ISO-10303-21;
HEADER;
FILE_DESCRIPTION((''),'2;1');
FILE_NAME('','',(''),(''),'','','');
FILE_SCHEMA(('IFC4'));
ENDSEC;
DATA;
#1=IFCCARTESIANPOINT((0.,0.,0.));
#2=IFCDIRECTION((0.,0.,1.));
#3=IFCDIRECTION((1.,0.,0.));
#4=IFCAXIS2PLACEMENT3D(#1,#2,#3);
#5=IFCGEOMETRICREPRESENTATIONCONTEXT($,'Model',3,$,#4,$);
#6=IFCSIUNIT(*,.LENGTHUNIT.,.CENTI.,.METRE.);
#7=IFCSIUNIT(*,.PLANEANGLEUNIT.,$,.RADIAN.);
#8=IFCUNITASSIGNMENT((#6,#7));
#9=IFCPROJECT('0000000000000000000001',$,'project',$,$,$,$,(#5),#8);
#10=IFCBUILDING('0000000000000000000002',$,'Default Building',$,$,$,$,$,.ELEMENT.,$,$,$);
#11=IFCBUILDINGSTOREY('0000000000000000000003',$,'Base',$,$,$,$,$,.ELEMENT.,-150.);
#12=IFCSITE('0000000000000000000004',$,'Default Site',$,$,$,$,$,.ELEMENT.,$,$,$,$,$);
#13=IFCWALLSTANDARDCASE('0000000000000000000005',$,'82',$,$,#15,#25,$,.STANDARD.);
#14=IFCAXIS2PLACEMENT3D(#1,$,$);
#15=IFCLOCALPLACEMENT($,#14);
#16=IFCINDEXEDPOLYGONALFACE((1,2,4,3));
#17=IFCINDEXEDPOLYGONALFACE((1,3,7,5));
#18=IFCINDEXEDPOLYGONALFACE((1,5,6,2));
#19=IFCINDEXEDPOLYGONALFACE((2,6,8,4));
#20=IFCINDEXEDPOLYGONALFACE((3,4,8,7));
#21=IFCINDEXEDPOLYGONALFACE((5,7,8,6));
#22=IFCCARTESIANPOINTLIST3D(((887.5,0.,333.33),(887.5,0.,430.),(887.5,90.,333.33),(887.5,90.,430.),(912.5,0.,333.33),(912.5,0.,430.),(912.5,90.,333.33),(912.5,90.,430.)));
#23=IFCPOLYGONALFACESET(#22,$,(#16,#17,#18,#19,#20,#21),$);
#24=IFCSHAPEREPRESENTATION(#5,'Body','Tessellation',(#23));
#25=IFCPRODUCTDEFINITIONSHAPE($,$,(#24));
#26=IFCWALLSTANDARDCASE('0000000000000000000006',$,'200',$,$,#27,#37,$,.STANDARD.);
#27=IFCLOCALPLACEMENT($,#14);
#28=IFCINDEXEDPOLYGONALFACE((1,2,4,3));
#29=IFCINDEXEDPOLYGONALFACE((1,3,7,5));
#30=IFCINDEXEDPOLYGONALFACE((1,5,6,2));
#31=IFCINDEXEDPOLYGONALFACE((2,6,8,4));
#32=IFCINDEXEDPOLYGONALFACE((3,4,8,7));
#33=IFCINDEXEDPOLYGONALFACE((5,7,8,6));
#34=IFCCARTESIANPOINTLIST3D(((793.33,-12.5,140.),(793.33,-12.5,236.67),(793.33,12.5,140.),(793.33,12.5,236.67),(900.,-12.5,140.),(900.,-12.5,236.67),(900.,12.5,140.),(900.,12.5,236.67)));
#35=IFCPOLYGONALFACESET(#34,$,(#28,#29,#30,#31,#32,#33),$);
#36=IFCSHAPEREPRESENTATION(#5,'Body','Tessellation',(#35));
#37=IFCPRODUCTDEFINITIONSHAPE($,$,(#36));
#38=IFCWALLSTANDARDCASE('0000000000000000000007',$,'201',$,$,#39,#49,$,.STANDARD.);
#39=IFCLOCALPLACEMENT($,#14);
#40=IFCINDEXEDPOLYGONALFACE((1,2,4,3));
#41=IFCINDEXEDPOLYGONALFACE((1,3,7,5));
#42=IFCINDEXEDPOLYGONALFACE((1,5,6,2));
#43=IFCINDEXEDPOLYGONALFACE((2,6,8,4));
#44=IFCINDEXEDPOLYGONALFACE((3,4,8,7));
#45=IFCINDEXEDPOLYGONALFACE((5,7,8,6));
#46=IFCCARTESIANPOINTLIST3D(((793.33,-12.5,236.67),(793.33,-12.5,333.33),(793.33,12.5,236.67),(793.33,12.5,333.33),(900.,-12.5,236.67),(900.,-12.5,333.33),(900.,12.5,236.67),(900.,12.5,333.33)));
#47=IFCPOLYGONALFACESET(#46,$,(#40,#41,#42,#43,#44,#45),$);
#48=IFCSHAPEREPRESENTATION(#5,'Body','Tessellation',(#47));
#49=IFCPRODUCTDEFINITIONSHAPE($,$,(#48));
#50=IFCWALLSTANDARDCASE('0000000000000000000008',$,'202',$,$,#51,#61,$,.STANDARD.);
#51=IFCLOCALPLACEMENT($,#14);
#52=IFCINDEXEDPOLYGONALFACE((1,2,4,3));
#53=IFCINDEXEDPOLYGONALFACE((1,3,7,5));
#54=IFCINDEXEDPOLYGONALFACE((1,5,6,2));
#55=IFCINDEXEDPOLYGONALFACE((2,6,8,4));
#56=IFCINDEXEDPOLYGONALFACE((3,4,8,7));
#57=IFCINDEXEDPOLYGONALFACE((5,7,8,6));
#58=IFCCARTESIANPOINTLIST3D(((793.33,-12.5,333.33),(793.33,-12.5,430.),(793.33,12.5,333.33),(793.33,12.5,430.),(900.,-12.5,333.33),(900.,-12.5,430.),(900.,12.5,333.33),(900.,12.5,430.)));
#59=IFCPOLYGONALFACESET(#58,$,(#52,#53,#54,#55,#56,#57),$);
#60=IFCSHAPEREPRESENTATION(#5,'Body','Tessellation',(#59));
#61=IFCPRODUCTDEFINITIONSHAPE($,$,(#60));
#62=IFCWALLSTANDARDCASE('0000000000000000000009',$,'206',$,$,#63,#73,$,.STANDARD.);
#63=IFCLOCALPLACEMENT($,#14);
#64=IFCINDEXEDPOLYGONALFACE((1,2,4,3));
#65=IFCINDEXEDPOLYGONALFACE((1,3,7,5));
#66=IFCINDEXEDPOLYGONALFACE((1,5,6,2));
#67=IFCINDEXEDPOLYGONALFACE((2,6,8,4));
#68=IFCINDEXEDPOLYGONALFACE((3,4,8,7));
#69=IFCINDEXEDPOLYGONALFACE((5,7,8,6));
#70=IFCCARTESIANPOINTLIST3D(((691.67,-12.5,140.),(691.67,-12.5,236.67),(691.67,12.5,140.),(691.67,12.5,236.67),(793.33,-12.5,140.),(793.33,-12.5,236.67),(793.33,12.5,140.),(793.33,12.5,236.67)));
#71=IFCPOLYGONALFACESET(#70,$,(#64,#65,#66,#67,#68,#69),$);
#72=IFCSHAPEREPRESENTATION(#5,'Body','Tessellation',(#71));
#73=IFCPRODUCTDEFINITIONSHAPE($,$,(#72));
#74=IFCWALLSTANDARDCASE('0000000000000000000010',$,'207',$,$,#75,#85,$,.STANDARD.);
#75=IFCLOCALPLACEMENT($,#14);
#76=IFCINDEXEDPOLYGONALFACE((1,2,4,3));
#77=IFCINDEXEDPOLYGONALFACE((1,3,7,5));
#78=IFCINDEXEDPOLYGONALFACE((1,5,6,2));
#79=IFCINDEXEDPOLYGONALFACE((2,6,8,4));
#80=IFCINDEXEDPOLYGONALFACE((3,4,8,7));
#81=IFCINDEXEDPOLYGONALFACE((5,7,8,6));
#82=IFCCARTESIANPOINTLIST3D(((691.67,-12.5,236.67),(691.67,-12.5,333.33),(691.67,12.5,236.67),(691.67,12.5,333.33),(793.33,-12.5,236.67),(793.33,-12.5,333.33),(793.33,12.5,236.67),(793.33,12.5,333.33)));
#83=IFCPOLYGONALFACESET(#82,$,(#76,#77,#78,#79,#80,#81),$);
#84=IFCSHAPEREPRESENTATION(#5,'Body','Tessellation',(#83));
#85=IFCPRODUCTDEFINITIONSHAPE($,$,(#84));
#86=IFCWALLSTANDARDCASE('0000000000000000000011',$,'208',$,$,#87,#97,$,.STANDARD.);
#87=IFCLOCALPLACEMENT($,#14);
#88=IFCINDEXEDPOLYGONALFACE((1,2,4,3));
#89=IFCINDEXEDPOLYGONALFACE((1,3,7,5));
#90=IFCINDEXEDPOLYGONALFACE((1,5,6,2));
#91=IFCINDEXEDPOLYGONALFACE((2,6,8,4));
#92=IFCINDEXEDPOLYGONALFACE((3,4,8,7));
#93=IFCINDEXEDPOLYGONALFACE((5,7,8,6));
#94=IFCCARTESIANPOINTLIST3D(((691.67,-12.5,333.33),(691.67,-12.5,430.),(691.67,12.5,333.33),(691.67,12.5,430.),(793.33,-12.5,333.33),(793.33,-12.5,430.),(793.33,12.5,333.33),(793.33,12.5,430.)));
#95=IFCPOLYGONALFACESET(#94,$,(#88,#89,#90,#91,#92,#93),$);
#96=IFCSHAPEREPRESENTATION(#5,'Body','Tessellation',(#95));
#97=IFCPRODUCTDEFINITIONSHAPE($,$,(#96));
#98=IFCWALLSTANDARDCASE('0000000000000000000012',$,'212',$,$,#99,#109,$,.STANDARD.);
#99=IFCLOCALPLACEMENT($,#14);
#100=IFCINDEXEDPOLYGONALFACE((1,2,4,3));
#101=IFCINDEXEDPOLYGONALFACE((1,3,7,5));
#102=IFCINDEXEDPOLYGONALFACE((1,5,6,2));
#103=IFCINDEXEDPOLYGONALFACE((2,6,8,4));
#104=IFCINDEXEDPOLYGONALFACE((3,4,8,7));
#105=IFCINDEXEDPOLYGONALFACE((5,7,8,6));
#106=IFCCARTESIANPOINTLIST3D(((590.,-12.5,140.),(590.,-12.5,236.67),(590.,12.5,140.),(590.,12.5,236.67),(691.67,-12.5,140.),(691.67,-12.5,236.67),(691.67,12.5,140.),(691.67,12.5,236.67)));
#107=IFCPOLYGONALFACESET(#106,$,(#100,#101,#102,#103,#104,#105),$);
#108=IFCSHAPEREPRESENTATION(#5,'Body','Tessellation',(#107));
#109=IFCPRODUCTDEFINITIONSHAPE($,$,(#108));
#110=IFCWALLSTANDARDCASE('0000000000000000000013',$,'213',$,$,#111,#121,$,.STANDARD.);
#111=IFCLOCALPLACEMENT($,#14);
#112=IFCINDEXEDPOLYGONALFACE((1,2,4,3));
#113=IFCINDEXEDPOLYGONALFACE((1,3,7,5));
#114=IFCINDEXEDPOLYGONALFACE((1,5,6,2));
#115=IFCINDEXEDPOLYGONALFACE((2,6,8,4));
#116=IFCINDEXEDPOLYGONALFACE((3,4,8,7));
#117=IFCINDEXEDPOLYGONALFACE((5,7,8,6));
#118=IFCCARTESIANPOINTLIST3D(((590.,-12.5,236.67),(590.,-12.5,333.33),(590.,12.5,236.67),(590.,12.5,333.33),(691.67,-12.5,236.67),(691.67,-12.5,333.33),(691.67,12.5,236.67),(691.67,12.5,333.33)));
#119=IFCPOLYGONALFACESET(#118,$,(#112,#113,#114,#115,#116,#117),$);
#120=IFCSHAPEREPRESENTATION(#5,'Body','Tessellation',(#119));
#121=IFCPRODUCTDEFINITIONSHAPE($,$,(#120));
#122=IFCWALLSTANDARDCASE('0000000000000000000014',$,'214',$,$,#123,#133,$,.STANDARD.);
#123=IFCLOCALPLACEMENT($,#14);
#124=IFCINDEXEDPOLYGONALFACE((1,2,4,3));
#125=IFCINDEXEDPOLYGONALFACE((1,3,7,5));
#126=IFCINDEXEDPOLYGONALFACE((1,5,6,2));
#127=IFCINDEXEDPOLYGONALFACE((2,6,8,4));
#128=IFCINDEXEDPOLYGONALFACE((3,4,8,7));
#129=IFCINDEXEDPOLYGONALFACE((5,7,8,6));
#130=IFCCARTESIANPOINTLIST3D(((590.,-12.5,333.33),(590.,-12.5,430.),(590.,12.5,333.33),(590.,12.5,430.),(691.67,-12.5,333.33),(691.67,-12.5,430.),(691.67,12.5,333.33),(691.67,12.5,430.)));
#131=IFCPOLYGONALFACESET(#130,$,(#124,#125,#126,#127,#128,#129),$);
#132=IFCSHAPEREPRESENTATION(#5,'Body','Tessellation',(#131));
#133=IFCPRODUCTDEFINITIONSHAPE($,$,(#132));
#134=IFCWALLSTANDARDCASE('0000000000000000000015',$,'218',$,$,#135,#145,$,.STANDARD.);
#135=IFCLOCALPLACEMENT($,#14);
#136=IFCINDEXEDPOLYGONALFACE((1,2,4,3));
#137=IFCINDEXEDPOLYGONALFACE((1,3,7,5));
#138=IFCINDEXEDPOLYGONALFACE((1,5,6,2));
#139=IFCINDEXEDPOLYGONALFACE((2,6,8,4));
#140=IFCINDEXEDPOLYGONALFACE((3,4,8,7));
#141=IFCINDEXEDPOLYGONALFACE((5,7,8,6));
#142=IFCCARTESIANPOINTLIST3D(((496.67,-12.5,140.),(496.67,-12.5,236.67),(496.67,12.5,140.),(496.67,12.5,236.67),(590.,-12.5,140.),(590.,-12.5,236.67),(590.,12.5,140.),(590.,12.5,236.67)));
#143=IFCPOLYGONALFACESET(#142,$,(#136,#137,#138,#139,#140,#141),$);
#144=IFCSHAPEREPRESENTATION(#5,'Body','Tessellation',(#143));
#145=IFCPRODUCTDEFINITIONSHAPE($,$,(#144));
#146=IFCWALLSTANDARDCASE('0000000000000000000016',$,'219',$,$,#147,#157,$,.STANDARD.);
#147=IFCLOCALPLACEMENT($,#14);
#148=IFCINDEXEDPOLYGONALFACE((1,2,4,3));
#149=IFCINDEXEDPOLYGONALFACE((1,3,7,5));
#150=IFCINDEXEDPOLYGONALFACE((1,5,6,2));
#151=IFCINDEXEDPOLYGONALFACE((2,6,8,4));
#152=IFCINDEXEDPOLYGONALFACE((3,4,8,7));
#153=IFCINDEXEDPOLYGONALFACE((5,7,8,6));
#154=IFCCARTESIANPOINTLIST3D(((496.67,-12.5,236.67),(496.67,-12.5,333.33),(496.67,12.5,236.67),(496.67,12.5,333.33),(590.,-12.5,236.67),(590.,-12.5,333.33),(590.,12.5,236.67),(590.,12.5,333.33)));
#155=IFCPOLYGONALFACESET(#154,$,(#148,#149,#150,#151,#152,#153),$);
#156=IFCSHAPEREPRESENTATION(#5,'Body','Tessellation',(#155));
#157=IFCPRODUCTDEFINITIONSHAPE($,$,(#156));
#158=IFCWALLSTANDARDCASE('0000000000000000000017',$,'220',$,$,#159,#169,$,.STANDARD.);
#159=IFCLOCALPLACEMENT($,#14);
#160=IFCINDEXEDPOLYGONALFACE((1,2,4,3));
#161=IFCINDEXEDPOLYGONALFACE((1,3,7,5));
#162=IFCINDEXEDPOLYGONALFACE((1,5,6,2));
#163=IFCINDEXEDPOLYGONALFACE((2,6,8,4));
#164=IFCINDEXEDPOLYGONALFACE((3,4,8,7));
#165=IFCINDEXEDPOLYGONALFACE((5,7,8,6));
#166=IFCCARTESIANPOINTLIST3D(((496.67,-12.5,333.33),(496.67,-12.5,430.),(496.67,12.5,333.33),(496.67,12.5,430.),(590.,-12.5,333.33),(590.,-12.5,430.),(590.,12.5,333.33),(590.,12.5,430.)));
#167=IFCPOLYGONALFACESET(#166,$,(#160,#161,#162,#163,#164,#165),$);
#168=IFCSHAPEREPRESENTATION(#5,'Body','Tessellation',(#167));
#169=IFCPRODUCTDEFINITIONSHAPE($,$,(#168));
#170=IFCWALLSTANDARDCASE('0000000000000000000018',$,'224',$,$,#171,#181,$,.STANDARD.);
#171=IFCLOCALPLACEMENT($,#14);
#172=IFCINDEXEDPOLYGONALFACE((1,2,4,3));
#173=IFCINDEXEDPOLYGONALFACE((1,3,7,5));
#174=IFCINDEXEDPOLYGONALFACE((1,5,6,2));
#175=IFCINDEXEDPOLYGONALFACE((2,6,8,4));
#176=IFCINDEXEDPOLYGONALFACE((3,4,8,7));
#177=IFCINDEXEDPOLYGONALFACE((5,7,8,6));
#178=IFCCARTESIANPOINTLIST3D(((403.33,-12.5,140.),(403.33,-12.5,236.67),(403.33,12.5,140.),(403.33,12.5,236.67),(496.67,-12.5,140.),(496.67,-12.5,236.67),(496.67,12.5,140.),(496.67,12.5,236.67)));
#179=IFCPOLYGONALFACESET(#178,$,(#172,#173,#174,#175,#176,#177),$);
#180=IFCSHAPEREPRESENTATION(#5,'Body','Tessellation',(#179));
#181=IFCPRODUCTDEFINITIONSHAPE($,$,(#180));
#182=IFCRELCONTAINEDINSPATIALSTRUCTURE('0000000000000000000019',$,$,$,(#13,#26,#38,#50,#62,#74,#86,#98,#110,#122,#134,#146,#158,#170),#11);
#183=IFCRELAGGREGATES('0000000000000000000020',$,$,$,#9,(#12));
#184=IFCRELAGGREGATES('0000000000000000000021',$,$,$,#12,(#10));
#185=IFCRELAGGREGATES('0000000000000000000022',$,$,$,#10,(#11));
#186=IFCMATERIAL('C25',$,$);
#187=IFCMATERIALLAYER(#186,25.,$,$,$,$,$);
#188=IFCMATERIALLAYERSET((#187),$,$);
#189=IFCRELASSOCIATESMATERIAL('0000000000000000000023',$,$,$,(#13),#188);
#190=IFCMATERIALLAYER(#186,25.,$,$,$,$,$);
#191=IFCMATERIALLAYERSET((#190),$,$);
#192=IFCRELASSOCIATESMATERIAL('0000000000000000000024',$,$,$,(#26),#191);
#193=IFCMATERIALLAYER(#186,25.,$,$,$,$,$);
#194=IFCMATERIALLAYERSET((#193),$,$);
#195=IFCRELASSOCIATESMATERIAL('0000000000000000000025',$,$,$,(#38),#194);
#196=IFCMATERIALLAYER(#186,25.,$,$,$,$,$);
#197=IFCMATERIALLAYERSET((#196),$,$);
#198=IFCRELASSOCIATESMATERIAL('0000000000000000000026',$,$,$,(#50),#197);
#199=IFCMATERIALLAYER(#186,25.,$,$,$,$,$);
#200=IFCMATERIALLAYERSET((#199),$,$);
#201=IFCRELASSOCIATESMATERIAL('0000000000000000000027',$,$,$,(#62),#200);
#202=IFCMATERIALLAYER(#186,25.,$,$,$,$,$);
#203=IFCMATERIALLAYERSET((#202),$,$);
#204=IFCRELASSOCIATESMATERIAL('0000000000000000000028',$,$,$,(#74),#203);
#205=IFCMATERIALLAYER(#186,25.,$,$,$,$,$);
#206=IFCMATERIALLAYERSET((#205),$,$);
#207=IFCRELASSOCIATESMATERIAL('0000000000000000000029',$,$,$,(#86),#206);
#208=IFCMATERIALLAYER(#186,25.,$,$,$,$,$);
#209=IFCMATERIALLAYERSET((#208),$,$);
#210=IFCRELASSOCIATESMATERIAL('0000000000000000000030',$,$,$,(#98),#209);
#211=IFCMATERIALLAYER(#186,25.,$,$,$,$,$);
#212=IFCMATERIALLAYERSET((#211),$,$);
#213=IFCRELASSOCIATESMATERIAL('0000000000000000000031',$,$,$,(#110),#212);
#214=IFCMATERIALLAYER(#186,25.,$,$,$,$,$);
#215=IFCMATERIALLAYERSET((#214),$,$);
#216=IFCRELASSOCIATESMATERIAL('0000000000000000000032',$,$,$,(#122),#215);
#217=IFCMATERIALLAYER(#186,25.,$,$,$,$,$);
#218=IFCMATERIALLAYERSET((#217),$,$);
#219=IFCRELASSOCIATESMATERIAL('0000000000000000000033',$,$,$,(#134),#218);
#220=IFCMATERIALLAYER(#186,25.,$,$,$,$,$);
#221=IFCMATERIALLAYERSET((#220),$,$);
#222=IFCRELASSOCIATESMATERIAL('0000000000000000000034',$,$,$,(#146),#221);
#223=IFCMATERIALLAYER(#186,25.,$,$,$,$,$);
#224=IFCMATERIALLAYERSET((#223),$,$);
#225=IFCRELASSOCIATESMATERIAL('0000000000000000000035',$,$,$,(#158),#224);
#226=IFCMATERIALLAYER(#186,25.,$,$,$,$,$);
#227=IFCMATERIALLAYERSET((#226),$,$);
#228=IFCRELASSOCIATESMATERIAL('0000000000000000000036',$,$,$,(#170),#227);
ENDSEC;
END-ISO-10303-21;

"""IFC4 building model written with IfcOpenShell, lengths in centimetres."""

from ifc_helpers import new_model, si_unit, frame, origin_with_axes, origin_2d_with_axis, place, context, project, spatial, rectangle, extrude, material, layer, layer_set, layer_usage, element, save


model = new_model("IFC4")

# Units and contexts
model_context = context("Model", 3, world=origin_with_axes())
ifc_project = project(units=[si_unit("LENGTHUNIT", "METRE", prefix="CENTI"), si_unit("PLANEANGLEUNIT", "RADIAN")], contexts=[model_context])

# Site, building, storey
site = spatial("IfcSite", under=ifc_project, Name="Default Site", CompositionType="ELEMENT")
building = spatial("IfcBuilding", under=site, Name="Default Building", CompositionType="ELEMENT")
storey = spatial("IfcBuildingStorey", under=building, Name="Base", CompositionType="ELEMENT", Elevation=-150.0)

# Walls
ifc_material = material(Name="C25")
ifc_layer_1 = layer(ifc_material, 25.0)
ifc_layer_set_1 = layer_set([ifc_layer_1])
ifc_layer_usage_1 = layer_usage(ifc_layer_set_1, "AXIS2", "POSITIVE", -25.0)
wall_1_placement = place(None, frame((900.0, 45.0, 333.33), z_axis=(0.0, 0.0, 1.0), x_axis=(0.0, -1.0, 0.0)))
element("IfcWallStandardCase", 1, at=wall_1_placement, inside=storey, material=ifc_layer_usage_1, Name="82", PredefinedType="STANDARD", context=model_context, shape_type="SweptSolid", body=[
    extrude(rectangle(XDim=90.0, YDim=25.0, at=origin_2d_with_axis()), origin_with_axes(), (0.0, 0.0, 1.0), 96.67),
])
ifc_layer_2 = layer(ifc_material, 25.0)
ifc_layer_set_2 = layer_set([ifc_layer_2])
ifc_layer_usage_2 = layer_usage(ifc_layer_set_2, "AXIS2", "POSITIVE", -25.0)
wall_2_placement = place(None, frame((846.67, 0.0, 140.0), z_axis=(0.0, 0.0, 1.0), x_axis=(-1.0, 0.0, 0.0)))
element("IfcWallStandardCase", 2, at=wall_2_placement, inside=storey, material=ifc_layer_usage_2, Name="200", PredefinedType="STANDARD", context=model_context, shape_type="SweptSolid", body=[
    extrude(rectangle(XDim=106.67, YDim=25.0, at=origin_2d_with_axis()), origin_with_axes(), (0.0, 0.0, 1.0), 96.67),
])
ifc_layer_3 = layer(ifc_material, 25.0)
ifc_layer_set_3 = layer_set([ifc_layer_3])
ifc_layer_usage_3 = layer_usage(ifc_layer_set_3, "AXIS2", "POSITIVE", -25.0)
wall_3_placement = place(None, frame((846.67, 0.0, 236.67), z_axis=(0.0, 0.0, 1.0), x_axis=(-1.0, 0.0, 0.0)))
element("IfcWallStandardCase", 3, at=wall_3_placement, inside=storey, material=ifc_layer_usage_3, Name="201", PredefinedType="STANDARD", context=model_context, shape_type="SweptSolid", body=[
    extrude(rectangle(XDim=106.67, YDim=25.0, at=origin_2d_with_axis()), origin_with_axes(), (0.0, 0.0, 1.0), 96.67),
])
ifc_layer_4 = layer(ifc_material, 25.0)
ifc_layer_set_4 = layer_set([ifc_layer_4])
ifc_layer_usage_4 = layer_usage(ifc_layer_set_4, "AXIS2", "POSITIVE", -25.0)
wall_4_placement = place(None, frame((846.67, 0.0, 333.33), z_axis=(0.0, 0.0, 1.0), x_axis=(-1.0, 0.0, 0.0)))
element("IfcWallStandardCase", 4, at=wall_4_placement, inside=storey, material=ifc_layer_usage_4, Name="202", PredefinedType="STANDARD", context=model_context, shape_type="SweptSolid", body=[
    extrude(rectangle(XDim=106.67, YDim=25.0, at=origin_2d_with_axis()), origin_with_axes(), (0.0, 0.0, 1.0), 96.67),
])
ifc_layer_5 = layer(ifc_material, 25.0)
ifc_layer_set_5 = layer_set([ifc_layer_5])
ifc_layer_usage_5 = layer_usage(ifc_layer_set_5, "AXIS2", "POSITIVE", -25.0)
wall_5_placement = place(None, frame((742.5, 0.0, 140.0), z_axis=(0.0, 0.0, 1.0), x_axis=(-1.0, 0.0, 0.0)))
element("IfcWallStandardCase", 5, at=wall_5_placement, inside=storey, material=ifc_layer_usage_5, Name="206", PredefinedType="STANDARD", context=model_context, shape_type="SweptSolid", body=[
    extrude(rectangle(XDim=101.67, YDim=25.0, at=origin_2d_with_axis()), origin_with_axes(), (0.0, 0.0, 1.0), 96.67),
])
ifc_layer_6 = layer(ifc_material, 25.0)
ifc_layer_set_6 = layer_set([ifc_layer_6])
ifc_layer_usage_6 = layer_usage(ifc_layer_set_6, "AXIS2", "POSITIVE", -25.0)
wall_6_placement = place(None, frame((742.5, 0.0, 236.67), z_axis=(0.0, 0.0, 1.0), x_axis=(-1.0, 0.0, 0.0)))
element("IfcWallStandardCase", 6, at=wall_6_placement, inside=storey, material=ifc_layer_usage_6, Name="207", PredefinedType="STANDARD", context=model_context, shape_type="SweptSolid", body=[
    extrude(rectangle(XDim=101.67, YDim=25.0, at=origin_2d_with_axis()), origin_with_axes(), (0.0, 0.0, 1.0), 96.67),
])
ifc_layer_7 = layer(ifc_material, 25.0)
ifc_layer_set_7 = layer_set([ifc_layer_7])
ifc_layer_usage_7 = layer_usage(ifc_layer_set_7, "AXIS2", "POSITIVE", -25.0)
wall_7_placement = place(None, frame((742.5, 0.0, 333.33), z_axis=(0.0, 0.0, 1.0), x_axis=(-1.0, 0.0, 0.0)))
element("IfcWallStandardCase", 7, at=wall_7_placement, inside=storey, material=ifc_layer_usage_7, Name="208", PredefinedType="STANDARD", context=model_context, shape_type="SweptSolid", body=[
    extrude(rectangle(XDim=101.67, YDim=25.0, at=origin_2d_with_axis()), origin_with_axes(), (0.0, 0.0, 1.0), 96.67),
])
ifc_layer_8 = layer(ifc_material, 25.0)
ifc_layer_set_8 = layer_set([ifc_layer_8])
ifc_layer_usage_8 = layer_usage(ifc_layer_set_8, "AXIS2", "POSITIVE", -25.0)
wall_8_placement = place(None, frame((640.83, 0.0, 140.0), z_axis=(0.0, 0.0, 1.0), x_axis=(-1.0, 0.0, 0.0)))
element("IfcWallStandardCase", 8, at=wall_8_placement, inside=storey, material=ifc_layer_usage_8, Name="212", PredefinedType="STANDARD", context=model_context, shape_type="SweptSolid", body=[
    extrude(rectangle(XDim=101.67, YDim=25.0, at=origin_2d_with_axis()), origin_with_axes(), (0.0, 0.0, 1.0), 96.67),
])
ifc_layer_9 = layer(ifc_material, 25.0)
ifc_layer_set_9 = layer_set([ifc_layer_9])
ifc_layer_usage_9 = layer_usage(ifc_layer_set_9, "AXIS2", "POSITIVE", -25.0)
wall_9_placement = place(None, frame((640.83, 0.0, 236.67), z_axis=(0.0, 0.0, 1.0), x_axis=(-1.0, 0.0, 0.0)))
element("IfcWallStandardCase", 9, at=wall_9_placement, inside=storey, material=ifc_layer_usage_9, Name="213", PredefinedType="STANDARD", context=model_context, shape_type="SweptSolid", body=[
    extrude(rectangle(XDim=101.67, YDim=25.0, at=origin_2d_with_axis()), origin_with_axes(), (0.0, 0.0, 1.0), 96.67),
])
ifc_layer_10 = layer(ifc_material, 25.0)
ifc_layer_set_10 = layer_set([ifc_layer_10])
ifc_layer_usage_10 = layer_usage(ifc_layer_set_10, "AXIS2", "POSITIVE", -25.0)
wall_10_placement = place(None, frame((640.83, 0.0, 333.33), z_axis=(0.0, 0.0, 1.0), x_axis=(-1.0, 0.0, 0.0)))
element("IfcWallStandardCase", 10, at=wall_10_placement, inside=storey, material=ifc_layer_usage_10, Name="214", PredefinedType="STANDARD", context=model_context, shape_type="SweptSolid", body=[
    extrude(rectangle(XDim=101.67, YDim=25.0, at=origin_2d_with_axis()), origin_with_axes(), (0.0, 0.0, 1.0), 96.67),
])
ifc_layer_11 = layer(ifc_material, 25.0)
ifc_layer_set_11 = layer_set([ifc_layer_11])
ifc_layer_usage_11 = layer_usage(ifc_layer_set_11, "AXIS2", "POSITIVE", -25.0)
wall_11_placement = place(None, frame((543.33, 0.0, 140.0), z_axis=(0.0, 0.0, 1.0), x_axis=(-1.0, 0.0, 0.0)))
element("IfcWallStandardCase", 11, at=wall_11_placement, inside=storey, material=ifc_layer_usage_11, Name="218", PredefinedType="STANDARD", context=model_context, shape_type="SweptSolid", body=[
    extrude(rectangle(XDim=93.33, YDim=25.0, at=origin_2d_with_axis()), origin_with_axes(), (0.0, 0.0, 1.0), 96.67),
])
ifc_layer_12 = layer(ifc_material, 25.0)
ifc_layer_set_12 = layer_set([ifc_layer_12])
ifc_layer_usage_12 = layer_usage(ifc_layer_set_12, "AXIS2", "POSITIVE", -25.0)
wall_12_placement = place(None, frame((543.33, 0.0, 236.67), z_axis=(0.0, 0.0, 1.0), x_axis=(-1.0, 0.0, 0.0)))
element("IfcWallStandardCase", 12, at=wall_12_placement, inside=storey, material=ifc_layer_usage_12, Name="219", PredefinedType="STANDARD", context=model_context, shape_type="SweptSolid", body=[
    extrude(rectangle(XDim=93.33, YDim=25.0, at=origin_2d_with_axis()), origin_with_axes(), (0.0, 0.0, 1.0), 96.67),
])
ifc_layer_13 = layer(ifc_material, 25.0)
ifc_layer_set_13 = layer_set([ifc_layer_13])
ifc_layer_usage_13 = layer_usage(ifc_layer_set_13, "AXIS2", "POSITIVE", -25.0)
wall_13_placement = place(None, frame((543.33, 0.0, 333.33), z_axis=(0.0, 0.0, 1.0), x_axis=(-1.0, 0.0, 0.0)))
element("IfcWallStandardCase", 13, at=wall_13_placement, inside=storey, material=ifc_layer_usage_13, Name="220", PredefinedType="STANDARD", context=model_context, shape_type="SweptSolid", body=[
    extrude(rectangle(XDim=93.33, YDim=25.0, at=origin_2d_with_axis()), origin_with_axes(), (0.0, 0.0, 1.0), 96.67),
])
ifc_layer_14 = layer(ifc_material, 25.0)
ifc_layer_set_14 = layer_set([ifc_layer_14])
ifc_layer_usage_14 = layer_usage(ifc_layer_set_14, "AXIS2", "POSITIVE", -25.0)
wall_14_placement = place(None, frame((450.0, 0.0, 140.0), z_axis=(0.0, 0.0, 1.0), x_axis=(-1.0, 0.0, 0.0)))
element("IfcWallStandardCase", 14, at=wall_14_placement, inside=storey, material=ifc_layer_usage_14, Name="224", PredefinedType="STANDARD", context=model_context, shape_type="SweptSolid", body=[
    extrude(rectangle(XDim=93.33, YDim=25.0, at=origin_2d_with_axis()), origin_with_axes(), (0.0, 0.0, 1.0), 96.67),
])

save(model, "model.ifc")
